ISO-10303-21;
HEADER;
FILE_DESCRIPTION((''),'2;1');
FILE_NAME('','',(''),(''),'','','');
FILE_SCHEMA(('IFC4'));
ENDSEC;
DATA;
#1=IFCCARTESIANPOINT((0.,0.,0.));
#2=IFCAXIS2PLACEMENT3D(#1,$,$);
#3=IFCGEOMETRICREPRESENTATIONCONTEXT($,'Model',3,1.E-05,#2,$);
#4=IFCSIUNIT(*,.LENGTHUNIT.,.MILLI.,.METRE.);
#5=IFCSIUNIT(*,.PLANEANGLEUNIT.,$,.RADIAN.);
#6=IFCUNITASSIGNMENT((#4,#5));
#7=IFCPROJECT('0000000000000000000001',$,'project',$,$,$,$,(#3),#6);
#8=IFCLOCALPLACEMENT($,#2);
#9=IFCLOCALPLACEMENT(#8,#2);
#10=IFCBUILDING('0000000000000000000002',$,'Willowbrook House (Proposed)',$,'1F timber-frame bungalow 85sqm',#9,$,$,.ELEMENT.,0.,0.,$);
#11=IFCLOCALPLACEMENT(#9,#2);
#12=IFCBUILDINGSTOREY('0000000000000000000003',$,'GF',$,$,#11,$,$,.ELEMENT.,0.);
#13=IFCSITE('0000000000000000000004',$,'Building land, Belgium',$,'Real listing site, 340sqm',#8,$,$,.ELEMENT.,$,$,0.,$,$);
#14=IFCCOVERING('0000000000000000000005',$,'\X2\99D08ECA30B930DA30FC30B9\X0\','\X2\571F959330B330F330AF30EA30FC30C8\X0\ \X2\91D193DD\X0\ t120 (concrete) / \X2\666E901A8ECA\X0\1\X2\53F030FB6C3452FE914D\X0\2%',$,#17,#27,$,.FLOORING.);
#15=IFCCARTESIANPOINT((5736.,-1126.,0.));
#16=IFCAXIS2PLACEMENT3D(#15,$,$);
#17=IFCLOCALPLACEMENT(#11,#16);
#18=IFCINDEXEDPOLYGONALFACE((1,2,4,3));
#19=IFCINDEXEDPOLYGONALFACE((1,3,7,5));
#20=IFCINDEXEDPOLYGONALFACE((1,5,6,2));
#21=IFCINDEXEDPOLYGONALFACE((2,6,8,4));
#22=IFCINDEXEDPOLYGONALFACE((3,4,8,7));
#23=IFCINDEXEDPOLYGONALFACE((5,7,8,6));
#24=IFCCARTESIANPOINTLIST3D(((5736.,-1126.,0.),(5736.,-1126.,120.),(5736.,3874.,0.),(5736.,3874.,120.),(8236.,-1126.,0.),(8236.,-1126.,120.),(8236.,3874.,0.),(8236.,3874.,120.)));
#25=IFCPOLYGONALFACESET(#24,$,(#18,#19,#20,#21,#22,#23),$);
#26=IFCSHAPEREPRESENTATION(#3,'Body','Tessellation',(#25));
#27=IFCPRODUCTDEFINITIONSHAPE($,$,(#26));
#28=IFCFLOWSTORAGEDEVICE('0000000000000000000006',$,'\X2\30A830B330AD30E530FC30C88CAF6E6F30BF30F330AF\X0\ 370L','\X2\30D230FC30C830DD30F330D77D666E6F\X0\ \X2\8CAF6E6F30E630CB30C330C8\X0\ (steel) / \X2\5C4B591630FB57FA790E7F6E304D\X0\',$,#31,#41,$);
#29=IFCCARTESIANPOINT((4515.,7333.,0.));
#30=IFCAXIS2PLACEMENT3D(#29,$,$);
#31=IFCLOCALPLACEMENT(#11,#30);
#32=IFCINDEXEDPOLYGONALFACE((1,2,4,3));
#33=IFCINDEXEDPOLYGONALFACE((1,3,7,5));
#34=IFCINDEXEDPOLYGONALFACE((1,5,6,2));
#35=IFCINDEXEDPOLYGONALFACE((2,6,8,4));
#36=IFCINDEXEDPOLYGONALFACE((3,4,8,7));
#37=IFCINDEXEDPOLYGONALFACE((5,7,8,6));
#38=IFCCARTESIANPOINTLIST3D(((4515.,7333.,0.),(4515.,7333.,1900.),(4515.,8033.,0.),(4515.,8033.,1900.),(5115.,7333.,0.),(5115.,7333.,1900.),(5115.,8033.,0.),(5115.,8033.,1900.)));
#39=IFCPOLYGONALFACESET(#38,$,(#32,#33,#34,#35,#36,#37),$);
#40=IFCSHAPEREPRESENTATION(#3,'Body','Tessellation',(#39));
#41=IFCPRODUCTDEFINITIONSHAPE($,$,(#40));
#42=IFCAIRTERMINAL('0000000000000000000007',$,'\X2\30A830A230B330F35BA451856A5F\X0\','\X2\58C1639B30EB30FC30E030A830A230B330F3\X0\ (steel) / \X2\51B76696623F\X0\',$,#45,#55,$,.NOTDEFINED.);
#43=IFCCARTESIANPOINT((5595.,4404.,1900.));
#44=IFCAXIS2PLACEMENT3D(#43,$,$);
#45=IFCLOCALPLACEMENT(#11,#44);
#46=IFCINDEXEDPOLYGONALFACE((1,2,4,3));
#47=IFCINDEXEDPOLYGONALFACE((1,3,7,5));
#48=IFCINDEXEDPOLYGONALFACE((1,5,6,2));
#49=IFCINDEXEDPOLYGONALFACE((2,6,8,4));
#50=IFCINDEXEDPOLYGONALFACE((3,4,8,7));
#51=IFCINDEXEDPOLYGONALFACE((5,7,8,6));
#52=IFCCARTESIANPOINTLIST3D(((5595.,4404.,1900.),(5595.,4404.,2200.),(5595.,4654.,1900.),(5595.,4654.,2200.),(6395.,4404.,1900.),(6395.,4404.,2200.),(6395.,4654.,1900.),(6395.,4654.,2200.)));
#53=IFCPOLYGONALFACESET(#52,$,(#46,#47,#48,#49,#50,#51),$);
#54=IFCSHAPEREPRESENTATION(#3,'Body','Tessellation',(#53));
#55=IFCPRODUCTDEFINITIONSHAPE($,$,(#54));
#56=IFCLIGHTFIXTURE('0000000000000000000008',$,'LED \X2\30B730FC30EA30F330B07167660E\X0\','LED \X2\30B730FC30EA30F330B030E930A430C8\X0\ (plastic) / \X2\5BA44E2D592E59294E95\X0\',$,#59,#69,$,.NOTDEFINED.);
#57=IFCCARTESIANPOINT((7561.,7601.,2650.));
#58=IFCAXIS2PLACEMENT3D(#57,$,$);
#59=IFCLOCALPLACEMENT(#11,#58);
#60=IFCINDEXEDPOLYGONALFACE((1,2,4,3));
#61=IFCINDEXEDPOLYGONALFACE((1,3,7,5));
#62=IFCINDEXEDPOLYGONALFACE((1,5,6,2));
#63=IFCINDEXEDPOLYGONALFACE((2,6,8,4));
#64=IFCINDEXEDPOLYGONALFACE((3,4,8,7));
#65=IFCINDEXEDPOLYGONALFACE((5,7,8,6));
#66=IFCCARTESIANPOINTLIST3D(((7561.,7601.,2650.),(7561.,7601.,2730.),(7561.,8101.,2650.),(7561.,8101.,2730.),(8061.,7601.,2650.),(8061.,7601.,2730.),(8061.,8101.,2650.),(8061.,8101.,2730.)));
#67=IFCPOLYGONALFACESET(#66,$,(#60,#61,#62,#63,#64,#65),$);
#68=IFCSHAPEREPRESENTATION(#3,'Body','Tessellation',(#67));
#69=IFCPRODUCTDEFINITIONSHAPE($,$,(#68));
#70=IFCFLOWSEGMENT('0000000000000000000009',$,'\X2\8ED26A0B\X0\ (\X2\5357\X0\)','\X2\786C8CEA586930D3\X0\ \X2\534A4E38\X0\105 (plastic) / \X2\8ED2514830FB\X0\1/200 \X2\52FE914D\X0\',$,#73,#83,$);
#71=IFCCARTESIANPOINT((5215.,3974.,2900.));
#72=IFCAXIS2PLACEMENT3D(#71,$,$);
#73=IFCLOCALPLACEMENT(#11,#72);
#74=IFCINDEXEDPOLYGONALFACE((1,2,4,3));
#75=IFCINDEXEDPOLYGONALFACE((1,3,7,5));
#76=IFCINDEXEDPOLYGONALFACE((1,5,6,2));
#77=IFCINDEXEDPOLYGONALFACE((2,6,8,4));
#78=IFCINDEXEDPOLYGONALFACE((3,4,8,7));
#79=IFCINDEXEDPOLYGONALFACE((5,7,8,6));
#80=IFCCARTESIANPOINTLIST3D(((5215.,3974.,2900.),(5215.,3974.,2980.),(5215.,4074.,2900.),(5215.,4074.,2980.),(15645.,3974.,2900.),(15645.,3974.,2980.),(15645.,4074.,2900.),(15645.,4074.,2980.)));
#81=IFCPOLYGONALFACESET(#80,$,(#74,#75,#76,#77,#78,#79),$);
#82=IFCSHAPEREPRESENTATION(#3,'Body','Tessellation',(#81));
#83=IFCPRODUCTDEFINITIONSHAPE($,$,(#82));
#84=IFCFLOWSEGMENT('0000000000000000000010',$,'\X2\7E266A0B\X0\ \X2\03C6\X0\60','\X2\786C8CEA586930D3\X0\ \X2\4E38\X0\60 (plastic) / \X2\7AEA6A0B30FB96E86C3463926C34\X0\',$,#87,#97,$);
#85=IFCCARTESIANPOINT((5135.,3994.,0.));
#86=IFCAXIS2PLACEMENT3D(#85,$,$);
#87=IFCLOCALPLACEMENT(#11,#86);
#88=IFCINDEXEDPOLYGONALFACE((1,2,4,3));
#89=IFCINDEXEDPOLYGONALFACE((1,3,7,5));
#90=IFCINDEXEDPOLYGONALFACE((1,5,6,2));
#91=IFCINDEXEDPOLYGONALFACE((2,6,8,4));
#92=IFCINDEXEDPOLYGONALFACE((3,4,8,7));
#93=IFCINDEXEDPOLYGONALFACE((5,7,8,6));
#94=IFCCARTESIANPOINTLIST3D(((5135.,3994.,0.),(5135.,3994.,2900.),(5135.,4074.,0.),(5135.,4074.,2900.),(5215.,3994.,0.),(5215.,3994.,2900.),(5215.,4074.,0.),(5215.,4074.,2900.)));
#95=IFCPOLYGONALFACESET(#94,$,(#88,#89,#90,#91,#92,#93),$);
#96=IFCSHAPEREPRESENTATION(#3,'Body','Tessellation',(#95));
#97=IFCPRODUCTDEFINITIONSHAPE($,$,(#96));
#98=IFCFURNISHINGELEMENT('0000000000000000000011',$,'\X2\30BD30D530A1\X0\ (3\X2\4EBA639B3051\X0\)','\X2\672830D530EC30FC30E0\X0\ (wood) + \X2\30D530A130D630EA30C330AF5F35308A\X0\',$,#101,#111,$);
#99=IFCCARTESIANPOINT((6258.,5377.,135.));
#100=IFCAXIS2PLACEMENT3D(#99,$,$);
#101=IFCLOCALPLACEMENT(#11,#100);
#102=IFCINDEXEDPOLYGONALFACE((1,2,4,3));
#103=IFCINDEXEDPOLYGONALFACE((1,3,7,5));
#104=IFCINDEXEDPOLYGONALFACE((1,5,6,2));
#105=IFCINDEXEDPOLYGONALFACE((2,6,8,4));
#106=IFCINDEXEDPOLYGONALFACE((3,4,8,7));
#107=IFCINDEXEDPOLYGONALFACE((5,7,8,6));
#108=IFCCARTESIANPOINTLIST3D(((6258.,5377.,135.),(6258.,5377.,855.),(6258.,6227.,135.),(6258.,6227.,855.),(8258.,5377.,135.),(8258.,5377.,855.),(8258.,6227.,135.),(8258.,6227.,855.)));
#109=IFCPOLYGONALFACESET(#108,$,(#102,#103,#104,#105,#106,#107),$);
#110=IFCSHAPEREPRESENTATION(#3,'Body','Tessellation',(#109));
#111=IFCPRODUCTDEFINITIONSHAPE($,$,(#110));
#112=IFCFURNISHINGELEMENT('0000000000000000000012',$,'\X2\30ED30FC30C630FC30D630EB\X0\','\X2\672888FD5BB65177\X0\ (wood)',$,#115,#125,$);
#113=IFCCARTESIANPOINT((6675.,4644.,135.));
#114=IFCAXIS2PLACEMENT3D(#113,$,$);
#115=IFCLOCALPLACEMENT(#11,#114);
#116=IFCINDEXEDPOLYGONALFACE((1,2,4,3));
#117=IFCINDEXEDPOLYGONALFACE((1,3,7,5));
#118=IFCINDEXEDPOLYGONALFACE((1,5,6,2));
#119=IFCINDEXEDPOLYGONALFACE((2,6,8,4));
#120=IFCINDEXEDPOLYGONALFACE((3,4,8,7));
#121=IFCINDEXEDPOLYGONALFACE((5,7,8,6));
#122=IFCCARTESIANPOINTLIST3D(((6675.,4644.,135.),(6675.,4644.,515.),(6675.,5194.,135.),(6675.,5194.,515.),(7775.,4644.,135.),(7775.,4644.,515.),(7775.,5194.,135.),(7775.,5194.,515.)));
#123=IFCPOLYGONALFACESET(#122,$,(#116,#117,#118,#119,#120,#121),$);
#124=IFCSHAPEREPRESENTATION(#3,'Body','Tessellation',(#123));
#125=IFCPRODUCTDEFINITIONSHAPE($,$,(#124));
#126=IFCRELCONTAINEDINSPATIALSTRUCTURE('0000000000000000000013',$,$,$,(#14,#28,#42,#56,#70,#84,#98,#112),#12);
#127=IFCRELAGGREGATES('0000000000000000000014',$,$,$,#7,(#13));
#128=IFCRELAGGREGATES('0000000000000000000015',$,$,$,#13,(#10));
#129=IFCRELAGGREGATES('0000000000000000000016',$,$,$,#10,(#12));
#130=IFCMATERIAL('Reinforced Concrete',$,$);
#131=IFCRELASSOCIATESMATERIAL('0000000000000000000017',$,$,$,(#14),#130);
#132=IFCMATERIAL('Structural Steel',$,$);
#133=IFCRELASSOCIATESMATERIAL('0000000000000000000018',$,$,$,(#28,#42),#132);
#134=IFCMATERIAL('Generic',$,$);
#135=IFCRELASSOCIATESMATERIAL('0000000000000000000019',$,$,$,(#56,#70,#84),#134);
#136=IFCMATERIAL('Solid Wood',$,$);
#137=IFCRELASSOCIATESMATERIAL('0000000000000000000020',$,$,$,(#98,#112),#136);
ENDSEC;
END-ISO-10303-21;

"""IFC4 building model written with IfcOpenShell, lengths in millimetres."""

from ifc_helpers import new_model, si_unit, frame, frame_2d, origin, place, context, project, spatial, rectangle, extrude, material, element, save


model = new_model("IFC4")

# Units and contexts
model_context = context("Model", 3, precision=1e-05, world=origin())
ifc_project = project(units=[si_unit("LENGTHUNIT", "METRE", prefix="MILLI"), si_unit("PLANEANGLEUNIT", "RADIAN")], contexts=[model_context])

# Site, building, storey
site_placement = place(None, origin())
site = spatial("IfcSite", under=ifc_project, at=site_placement, Name="Building land, Belgium", ObjectType="Real listing site, 340sqm", CompositionType="ELEMENT", RefElevation=0.0)
building_placement = place(site_placement, origin())
building = spatial("IfcBuilding", under=site, at=building_placement, Name="Willowbrook House (Proposed)", ObjectType="1F timber-frame bungalow 85sqm", CompositionType="ELEMENT", ElevationOfRefHeight=0.0, ElevationOfTerrain=0.0)
storey_placement = place(building_placement, origin())
storey = spatial("IfcBuildingStorey", under=building, at=storey_placement, Name="GF", CompositionType="ELEMENT", Elevation=0.0)

# Shared definitions
ifc_material_1 = material(Name="Solid Wood")

# Shared definitions
ifc_material_2 = material(Name="Reinforced Concrete")

# Shared definitions
ifc_material_3 = material(Name="Structural Steel")

# Covering
ifc_material_4 = material(Name="Generic")
covering_1_placement = place(storey_placement, frame((5736.0, -1126.0, 0.0)))
element("IfcCovering", 1, at=covering_1_placement, inside=storey, material=ifc_material_2, Name="駐車スペース", Description="土間コンクリート 金鏝 t120 (concrete) / 普通車1台・水勾配2%", PredefinedType="FLOORING", context=model_context, shape_type="SweptSolid", body=[
    extrude(rectangle(XDim=2500.0, YDim=5000.0, at=frame_2d((1250.0, 2500.0))), frame((5736.0, -1126.0, 0.0)), (0.0, 0.0, 1.0), 120.0),
])

# Flow storage device
flow_storage_device_placement = place(storey_placement, frame((4515.0, 7333.0, 0.0)))
element("IfcFlowStorageDevice", 2, at=flow_storage_device_placement, inside=storey, material=ifc_material_3, Name="エコキュート貯湯タンク 370L", Description="ヒートポンプ給湯 貯湯ユニット (steel) / 屋外・基礎置き", context=model_context, shape_type="SweptSolid", body=[
    extrude(rectangle(XDim=600.0, YDim=700.0, at=frame_2d((300.0, 350.0))), frame((4515.0, 7333.0, 0.0)), (0.0, 0.0, 1.0), 1900.0),
])

# Air terminal
air_terminal_placement = place(storey_placement, frame((5595.0, 4404.0, 1900.0)))
element("IfcAirTerminal", 3, at=air_terminal_placement, inside=storey, material=ifc_material_3, Name="エアコン室内機", Description="壁掛ルームエアコン (steel) / 冷暖房", PredefinedType="NOTDEFINED", context=model_context, shape_type="SweptSolid", body=[
    extrude(rectangle(XDim=800.0, YDim=250.0, at=frame_2d((400.0, 125.0))), frame((5595.0, 4404.0, 1900.0)), (0.0, 0.0, 1.0), 300.0),
])

# Light fixture
light_fixture_placement = place(storey_placement, frame((7561.0, 7601.0, 2650.0)))
element("IfcLightFixture", 4, at=light_fixture_placement, inside=storey, material=ifc_material_4, Name="LED シーリング照明", Description="LED シーリングライト (plastic) / 室中央天井", PredefinedType="NOTDEFINED", context=model_context, shape_type="SweptSolid", body=[
    extrude(rectangle(XDim=500.0, YDim=500.0, at=frame_2d((250.0, 250.0))), frame((7561.0, 7601.0, 2650.0)), (0.0, 0.0, 1.0), 80.0),
])

# Flow segments
flow_segment_1_placement = place(storey_placement, frame((5215.0, 3974.0, 2900.0)))
element("IfcFlowSegment", 5, at=flow_segment_1_placement, inside=storey, material=ifc_material_4, Name="軒樋 (南)", Description="硬質塩ビ 半丸105 (plastic) / 軒先・1/200 勾配", context=model_context, shape_type="SweptSolid", body=[
    extrude(rectangle(XDim=10430.0, YDim=100.0, at=frame_2d((5215.0, 50.0))), frame((5215.0, 3974.0, 2900.0)), (0.0, 0.0, 1.0), 80.0),
])
flow_segment_2_placement = place(storey_placement, frame((5135.0, 3994.0, 0.0)))
element("IfcFlowSegment", 6, at=flow_segment_2_placement, inside=storey, material=ifc_material_4, Name="縦樋 φ60", Description="硬質塩ビ 丸60 (plastic) / 竪樋・雨水排水", context=model_context, shape_type="SweptSolid", body=[
    extrude(rectangle(XDim=80.0, YDim=80.0, at=frame_2d((40.0, 40.0))), frame((5135.0, 3994.0, 0.0)), (0.0, 0.0, 1.0), 2900.0),
])

# Furnishing elements
furnishing_1_placement = place(storey_placement, frame((6258.0, 5377.0, 135.0)))
element("IfcFurnishingElement", 7, at=furnishing_1_placement, inside=storey, material=ifc_material_1, Name="ソファ (3人掛け)", Description="木フレーム (wood) + ファブリック張り", context=model_context, shape_type="SweptSolid", body=[
    extrude(rectangle(XDim=2000.0, YDim=850.0, at=frame_2d((1000.0, 425.0))), frame((6258.0, 5377.0, 135.0)), (0.0, 0.0, 1.0), 720.0),
])
furnishing_2_placement = place(storey_placement, frame((6675.0, 4644.0, 135.0)))
element("IfcFurnishingElement", 8, at=furnishing_2_placement, inside=storey, material=ifc_material_1, Name="ローテーブル", Description="木製家具 (wood)", context=model_context, shape_type="SweptSolid", body=[
    extrude(rectangle(XDim=1100.0, YDim=550.0, at=frame_2d((550.0, 275.0))), frame((6675.0, 4644.0, 135.0)), (0.0, 0.0, 1.0), 380.0),
])

save(model, "model.ifc")
